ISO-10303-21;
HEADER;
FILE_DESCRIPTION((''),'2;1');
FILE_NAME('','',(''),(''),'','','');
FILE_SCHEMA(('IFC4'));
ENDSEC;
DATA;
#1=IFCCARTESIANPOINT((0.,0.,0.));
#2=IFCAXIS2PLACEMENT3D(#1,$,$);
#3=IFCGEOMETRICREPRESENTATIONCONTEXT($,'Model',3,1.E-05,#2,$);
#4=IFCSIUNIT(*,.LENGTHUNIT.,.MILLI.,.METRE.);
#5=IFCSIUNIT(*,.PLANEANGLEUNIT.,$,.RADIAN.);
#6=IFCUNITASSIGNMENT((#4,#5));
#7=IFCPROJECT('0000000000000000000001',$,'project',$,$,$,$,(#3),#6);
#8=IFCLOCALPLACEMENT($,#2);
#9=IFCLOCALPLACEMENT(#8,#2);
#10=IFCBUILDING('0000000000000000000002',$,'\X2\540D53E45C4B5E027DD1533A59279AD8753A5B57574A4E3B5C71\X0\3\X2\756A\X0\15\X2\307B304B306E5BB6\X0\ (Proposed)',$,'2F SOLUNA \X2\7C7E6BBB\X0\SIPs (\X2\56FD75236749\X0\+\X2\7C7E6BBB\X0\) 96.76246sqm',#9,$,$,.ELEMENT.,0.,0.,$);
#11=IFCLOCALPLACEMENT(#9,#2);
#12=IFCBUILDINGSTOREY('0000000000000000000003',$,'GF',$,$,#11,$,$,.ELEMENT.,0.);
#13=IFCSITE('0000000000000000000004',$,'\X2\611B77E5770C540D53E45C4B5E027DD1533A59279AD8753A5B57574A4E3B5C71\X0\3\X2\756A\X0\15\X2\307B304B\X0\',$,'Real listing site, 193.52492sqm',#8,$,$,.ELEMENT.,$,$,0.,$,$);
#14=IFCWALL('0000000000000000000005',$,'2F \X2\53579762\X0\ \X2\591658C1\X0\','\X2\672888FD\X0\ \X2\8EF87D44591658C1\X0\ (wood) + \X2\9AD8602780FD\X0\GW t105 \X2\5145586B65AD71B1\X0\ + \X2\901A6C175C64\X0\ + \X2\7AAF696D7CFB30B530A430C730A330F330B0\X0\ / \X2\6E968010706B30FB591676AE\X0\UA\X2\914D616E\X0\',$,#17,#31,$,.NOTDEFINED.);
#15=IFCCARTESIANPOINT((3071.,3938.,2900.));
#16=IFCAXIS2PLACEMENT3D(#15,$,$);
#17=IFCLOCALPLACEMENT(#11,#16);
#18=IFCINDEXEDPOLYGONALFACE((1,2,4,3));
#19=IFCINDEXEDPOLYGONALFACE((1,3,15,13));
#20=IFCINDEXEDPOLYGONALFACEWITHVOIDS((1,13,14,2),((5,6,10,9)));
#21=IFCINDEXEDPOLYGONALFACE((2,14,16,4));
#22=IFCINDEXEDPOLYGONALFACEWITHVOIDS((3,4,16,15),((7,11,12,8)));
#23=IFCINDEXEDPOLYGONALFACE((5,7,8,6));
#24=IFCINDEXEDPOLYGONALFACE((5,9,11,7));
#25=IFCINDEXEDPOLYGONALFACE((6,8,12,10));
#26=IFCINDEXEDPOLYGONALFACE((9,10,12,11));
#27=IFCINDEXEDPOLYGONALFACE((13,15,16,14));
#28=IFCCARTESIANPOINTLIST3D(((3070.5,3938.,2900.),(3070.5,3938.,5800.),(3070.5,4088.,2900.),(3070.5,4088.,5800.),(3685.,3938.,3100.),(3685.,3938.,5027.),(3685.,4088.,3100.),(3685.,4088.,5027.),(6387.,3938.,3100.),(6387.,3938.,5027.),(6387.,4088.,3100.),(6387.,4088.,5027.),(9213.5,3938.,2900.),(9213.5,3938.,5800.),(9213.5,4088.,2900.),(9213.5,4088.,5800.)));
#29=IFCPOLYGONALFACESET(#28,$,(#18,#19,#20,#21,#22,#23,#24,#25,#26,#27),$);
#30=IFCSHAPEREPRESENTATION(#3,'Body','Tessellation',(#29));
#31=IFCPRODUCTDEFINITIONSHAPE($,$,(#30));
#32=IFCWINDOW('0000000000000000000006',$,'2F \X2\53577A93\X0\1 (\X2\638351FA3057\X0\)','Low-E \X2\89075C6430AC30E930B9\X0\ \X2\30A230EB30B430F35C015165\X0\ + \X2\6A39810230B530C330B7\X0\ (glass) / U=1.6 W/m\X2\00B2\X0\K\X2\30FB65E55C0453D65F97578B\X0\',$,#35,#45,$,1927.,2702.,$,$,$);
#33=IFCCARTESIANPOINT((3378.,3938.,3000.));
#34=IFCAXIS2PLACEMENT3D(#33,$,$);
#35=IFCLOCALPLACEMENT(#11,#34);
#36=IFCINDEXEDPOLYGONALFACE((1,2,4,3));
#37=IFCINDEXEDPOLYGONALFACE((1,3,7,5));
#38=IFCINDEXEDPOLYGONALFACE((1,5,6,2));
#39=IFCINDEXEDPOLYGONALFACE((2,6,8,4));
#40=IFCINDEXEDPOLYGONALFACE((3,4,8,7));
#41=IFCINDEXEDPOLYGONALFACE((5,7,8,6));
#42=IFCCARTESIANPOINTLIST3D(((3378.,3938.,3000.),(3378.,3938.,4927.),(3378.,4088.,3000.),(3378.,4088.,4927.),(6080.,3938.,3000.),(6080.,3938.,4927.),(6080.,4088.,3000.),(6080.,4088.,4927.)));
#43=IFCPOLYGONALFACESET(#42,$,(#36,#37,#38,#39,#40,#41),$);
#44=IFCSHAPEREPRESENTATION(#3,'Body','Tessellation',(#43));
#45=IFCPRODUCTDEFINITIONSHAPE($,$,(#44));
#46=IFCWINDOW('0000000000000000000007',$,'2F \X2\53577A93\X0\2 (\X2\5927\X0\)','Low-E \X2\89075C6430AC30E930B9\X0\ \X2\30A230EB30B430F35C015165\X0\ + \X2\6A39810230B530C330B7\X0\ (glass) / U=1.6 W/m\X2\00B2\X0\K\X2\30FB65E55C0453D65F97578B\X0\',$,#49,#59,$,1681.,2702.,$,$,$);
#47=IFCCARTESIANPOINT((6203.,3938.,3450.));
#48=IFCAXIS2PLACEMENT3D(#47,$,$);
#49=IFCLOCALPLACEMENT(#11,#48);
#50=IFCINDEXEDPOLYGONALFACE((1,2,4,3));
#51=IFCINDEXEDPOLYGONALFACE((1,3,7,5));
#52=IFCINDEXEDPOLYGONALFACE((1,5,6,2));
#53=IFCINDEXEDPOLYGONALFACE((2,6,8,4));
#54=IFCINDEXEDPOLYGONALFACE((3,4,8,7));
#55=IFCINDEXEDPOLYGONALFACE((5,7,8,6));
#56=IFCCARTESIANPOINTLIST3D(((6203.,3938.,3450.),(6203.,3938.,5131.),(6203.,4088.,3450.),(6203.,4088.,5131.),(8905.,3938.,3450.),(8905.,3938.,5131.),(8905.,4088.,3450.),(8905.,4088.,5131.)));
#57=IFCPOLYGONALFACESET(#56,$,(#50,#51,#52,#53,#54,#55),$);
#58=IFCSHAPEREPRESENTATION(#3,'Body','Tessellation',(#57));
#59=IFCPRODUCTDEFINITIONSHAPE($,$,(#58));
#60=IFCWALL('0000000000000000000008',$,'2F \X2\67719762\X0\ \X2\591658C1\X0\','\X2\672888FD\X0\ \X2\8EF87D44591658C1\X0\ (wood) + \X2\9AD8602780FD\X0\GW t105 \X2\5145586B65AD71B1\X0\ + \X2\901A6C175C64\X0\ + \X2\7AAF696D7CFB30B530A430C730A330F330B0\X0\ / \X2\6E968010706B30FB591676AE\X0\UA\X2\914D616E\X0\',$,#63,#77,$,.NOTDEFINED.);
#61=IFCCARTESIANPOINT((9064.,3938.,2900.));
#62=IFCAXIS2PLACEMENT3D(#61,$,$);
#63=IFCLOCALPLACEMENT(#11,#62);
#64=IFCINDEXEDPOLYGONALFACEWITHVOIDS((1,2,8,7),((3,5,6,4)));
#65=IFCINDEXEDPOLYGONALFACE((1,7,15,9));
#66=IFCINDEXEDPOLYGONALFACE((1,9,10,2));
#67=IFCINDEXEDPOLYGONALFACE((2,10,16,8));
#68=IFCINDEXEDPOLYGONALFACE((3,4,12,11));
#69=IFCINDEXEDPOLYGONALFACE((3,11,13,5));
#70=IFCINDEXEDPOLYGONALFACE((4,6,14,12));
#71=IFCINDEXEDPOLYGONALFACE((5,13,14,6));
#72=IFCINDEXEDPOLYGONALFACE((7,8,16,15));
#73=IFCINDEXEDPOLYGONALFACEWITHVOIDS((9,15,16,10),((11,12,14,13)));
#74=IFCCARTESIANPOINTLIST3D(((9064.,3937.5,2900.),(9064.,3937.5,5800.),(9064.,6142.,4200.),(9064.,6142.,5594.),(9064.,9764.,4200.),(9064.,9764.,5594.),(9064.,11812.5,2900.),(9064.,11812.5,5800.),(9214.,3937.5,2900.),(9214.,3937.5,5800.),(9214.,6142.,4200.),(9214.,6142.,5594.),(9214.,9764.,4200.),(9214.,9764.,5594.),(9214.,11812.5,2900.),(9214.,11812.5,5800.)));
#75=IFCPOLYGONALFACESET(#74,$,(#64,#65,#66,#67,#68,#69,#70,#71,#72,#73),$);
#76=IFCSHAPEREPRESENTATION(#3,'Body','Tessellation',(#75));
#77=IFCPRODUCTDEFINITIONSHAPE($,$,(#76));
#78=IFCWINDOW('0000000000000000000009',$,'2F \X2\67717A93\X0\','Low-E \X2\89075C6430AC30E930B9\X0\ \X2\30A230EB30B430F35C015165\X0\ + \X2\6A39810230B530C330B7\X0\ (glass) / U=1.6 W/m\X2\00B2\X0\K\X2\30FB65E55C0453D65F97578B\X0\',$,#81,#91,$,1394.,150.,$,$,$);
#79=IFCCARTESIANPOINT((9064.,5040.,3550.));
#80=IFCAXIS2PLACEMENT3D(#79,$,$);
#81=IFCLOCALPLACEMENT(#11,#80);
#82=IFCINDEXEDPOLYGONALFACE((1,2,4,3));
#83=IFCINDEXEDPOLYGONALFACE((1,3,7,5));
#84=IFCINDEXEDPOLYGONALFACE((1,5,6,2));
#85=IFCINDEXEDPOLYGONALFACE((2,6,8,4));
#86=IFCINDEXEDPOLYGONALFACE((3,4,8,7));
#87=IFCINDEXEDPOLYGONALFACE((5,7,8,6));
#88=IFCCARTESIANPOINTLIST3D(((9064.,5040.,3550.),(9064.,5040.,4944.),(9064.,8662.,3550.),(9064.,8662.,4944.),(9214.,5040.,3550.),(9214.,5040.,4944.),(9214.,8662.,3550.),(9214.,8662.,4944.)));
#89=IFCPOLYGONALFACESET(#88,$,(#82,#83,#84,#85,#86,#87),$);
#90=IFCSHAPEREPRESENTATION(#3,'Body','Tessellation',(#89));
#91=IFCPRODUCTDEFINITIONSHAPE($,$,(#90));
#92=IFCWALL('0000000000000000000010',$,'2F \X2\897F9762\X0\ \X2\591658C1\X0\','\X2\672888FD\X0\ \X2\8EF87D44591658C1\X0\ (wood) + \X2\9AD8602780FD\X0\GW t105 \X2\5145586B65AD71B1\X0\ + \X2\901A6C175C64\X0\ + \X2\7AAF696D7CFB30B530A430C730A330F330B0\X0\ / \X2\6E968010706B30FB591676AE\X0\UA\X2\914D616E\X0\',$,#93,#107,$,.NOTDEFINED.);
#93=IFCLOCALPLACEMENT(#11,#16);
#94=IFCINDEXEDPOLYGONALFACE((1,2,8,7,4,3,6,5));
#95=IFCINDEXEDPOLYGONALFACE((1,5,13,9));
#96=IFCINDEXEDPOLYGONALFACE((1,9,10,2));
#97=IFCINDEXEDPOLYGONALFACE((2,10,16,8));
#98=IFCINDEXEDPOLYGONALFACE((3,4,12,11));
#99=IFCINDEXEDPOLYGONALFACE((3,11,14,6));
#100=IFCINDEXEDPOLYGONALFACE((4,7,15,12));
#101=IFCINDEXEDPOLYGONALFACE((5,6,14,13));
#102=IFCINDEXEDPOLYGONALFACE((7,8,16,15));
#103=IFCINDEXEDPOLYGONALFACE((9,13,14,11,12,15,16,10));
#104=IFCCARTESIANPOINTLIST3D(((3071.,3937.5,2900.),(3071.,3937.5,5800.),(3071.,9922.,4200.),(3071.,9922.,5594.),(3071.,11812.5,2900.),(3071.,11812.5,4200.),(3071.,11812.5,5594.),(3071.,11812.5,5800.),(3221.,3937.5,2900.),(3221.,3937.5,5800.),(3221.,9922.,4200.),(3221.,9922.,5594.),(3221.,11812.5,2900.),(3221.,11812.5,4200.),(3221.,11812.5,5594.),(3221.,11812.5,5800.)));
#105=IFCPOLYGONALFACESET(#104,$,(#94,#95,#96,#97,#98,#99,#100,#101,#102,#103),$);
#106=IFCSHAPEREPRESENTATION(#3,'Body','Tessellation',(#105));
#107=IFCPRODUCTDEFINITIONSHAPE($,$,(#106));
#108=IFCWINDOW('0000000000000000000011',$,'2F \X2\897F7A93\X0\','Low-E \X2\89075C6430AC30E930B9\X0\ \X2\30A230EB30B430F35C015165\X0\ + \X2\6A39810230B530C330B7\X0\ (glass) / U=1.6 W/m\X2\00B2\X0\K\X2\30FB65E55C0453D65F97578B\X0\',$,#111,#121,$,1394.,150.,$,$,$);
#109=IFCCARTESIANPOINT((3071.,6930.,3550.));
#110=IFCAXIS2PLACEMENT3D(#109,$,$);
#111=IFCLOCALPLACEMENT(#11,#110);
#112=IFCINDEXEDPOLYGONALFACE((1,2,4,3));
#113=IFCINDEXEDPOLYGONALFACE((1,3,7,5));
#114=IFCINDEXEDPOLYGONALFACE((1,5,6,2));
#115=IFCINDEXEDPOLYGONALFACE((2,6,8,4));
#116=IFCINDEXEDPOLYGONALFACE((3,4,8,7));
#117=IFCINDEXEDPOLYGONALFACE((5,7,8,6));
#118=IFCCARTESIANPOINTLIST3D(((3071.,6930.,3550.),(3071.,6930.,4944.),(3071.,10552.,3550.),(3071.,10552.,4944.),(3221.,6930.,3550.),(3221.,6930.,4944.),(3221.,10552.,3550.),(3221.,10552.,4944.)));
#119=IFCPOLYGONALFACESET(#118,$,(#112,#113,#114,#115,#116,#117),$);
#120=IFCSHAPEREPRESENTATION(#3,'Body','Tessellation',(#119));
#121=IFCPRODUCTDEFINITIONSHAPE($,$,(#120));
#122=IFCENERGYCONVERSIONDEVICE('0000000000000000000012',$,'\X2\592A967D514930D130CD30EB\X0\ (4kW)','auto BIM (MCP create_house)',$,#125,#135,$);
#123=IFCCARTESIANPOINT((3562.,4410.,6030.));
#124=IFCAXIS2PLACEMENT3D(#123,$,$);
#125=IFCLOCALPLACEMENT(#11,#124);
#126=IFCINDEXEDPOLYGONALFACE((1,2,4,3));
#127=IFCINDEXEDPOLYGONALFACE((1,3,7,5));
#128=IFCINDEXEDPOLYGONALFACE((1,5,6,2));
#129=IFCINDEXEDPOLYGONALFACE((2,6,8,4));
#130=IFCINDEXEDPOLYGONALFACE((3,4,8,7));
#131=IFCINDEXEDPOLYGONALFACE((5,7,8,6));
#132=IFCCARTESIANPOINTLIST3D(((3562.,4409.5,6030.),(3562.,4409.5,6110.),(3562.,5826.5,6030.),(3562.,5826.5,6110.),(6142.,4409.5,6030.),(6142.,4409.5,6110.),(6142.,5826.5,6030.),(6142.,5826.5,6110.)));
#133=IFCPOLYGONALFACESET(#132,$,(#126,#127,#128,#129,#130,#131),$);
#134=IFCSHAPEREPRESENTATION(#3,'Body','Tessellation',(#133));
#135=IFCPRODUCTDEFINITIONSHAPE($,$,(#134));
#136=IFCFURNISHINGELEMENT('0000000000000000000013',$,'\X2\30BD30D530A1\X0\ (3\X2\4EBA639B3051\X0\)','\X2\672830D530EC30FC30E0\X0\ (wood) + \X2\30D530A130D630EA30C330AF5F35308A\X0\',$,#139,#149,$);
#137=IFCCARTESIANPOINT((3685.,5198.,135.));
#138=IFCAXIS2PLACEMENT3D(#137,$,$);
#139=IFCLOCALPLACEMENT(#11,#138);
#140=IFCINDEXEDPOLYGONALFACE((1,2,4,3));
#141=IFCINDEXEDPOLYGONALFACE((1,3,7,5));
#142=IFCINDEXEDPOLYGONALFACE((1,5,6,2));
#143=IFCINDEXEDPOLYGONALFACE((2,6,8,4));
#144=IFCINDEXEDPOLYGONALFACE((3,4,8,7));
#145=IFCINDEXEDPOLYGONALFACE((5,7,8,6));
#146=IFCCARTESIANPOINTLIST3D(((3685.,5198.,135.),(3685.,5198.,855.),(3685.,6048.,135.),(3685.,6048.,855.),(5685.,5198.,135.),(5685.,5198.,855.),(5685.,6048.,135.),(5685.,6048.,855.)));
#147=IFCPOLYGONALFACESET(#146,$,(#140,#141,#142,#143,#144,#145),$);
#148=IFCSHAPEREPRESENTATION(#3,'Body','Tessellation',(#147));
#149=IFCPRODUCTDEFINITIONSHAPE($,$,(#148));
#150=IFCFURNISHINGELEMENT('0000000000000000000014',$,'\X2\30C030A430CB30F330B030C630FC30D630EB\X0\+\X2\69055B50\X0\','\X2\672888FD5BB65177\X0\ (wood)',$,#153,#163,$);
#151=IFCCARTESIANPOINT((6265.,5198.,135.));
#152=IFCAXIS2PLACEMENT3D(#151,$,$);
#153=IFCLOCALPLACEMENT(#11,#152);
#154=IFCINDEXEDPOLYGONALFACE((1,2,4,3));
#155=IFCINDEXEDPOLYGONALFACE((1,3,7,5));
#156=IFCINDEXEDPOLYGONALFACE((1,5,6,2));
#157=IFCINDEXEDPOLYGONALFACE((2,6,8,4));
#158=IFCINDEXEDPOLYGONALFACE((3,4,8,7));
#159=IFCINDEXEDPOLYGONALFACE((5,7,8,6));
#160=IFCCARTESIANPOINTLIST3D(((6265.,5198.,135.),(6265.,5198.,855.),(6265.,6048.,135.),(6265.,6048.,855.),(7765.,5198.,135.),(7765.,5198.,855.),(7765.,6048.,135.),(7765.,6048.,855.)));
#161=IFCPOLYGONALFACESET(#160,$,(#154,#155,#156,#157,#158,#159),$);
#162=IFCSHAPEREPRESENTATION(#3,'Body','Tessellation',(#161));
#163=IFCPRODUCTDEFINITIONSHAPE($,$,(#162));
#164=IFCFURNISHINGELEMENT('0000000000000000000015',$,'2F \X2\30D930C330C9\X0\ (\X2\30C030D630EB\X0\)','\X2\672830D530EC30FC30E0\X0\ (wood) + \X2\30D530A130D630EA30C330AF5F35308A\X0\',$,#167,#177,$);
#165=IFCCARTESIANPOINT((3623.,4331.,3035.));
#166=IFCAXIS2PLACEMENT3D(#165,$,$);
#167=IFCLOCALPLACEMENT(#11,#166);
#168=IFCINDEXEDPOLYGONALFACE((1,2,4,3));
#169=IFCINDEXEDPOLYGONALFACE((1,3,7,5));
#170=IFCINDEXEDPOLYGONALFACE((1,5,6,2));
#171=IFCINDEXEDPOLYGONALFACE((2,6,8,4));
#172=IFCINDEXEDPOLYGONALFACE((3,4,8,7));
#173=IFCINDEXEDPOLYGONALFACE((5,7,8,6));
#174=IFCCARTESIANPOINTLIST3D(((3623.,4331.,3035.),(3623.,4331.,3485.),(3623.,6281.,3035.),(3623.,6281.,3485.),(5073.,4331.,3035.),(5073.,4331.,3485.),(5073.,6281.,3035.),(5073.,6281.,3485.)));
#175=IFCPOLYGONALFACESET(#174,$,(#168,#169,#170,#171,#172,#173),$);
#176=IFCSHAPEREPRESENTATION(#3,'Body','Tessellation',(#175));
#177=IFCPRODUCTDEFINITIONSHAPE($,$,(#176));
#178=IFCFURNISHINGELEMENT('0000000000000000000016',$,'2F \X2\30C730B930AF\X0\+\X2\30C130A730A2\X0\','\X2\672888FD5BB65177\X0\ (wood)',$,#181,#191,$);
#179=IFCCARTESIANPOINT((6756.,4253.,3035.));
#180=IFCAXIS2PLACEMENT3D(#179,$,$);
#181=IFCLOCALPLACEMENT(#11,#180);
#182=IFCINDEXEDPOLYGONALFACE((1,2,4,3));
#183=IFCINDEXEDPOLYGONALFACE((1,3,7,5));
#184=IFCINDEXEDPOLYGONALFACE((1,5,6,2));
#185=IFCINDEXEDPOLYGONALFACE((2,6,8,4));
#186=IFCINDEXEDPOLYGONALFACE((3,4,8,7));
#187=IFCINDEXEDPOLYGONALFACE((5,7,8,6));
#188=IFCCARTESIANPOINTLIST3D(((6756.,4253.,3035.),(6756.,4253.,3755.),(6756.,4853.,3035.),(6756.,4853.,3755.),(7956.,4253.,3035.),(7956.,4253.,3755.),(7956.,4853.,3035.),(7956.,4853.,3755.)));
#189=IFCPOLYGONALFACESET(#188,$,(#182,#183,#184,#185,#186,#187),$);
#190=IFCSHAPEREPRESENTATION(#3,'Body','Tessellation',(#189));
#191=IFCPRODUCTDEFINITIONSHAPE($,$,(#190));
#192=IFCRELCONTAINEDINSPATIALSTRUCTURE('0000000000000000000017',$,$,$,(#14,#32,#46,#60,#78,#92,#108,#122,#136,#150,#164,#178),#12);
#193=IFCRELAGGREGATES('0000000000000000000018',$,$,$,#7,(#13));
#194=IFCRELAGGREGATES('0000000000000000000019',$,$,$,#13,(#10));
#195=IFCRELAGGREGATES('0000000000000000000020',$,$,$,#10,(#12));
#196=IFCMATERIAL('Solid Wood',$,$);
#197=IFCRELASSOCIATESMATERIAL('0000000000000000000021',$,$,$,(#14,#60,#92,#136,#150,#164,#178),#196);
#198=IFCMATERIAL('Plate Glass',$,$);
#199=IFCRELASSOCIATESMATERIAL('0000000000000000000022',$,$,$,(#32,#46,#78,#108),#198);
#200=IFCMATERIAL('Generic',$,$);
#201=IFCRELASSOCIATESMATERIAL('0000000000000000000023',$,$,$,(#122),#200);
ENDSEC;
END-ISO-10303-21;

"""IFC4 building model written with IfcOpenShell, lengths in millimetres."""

from ifc_helpers import new_model, si_unit, frame, frame_2d, origin, place, context, project, spatial, rectangle, extrude, material, element, fill, save


model = new_model("IFC4")

# Units and contexts
model_context = context("Model", 3, precision=1e-05, world=origin())
ifc_project = project(units=[si_unit("LENGTHUNIT", "METRE", prefix="MILLI"), si_unit("PLANEANGLEUNIT", "RADIAN")], contexts=[model_context])

# Site, building, storey
site_placement = place(None, origin())
site = spatial("IfcSite", under=ifc_project, at=site_placement, Name="愛知県名古屋市緑区大高町字坊主山3番15ほか", ObjectType="Real listing site, 193.52492sqm", CompositionType="ELEMENT", RefElevation=0.0)
building_placement = place(site_placement, origin())
building = spatial("IfcBuilding", under=site, at=building_placement, Name="名古屋市緑区大高町字坊主山3番15ほかの家 (Proposed)", ObjectType="2F SOLUNA 籾殻SIPs (国産杉+籾殻) 96.76246sqm", CompositionType="ELEMENT", ElevationOfRefHeight=0.0, ElevationOfTerrain=0.0)
storey_placement = place(building_placement, origin())
storey = spatial("IfcBuildingStorey", under=building, at=storey_placement, Name="GF", CompositionType="ELEMENT", Elevation=0.0)

# Shared definitions
ifc_material_1 = material(Name="Solid Wood")

# Wall, openings, windows
wall_1_placement = place(storey_placement, frame((3071.0, 3938.0, 2900.0)))
wall_1 = element("IfcWall", 1, at=wall_1_placement, inside=storey, material=ifc_material_1, Name="2F 南面 外壁", Description="木製 軸組外壁 (wood) + 高性能GW t105 充填断熱 + 通気層 + 窯業系サイディング / 準耐火・外皮UA配慮", PredefinedType="NOTDEFINED", context=model_context, shape_type="SweptSolid", body=[
    extrude(rectangle(XDim=6143.0, YDim=150.0, at=frame_2d((3071.0, 75.0))), frame((3071.0, 3938.0, 2900.0)), (0.0, 0.0, 1.0), 2900.0),
])
opening_1_placement = place(storey_placement, frame((3378.0, 3938.0, 3000.0)))
opening_1 = element("IfcOpeningElement", 2, at=opening_1_placement, cuts=wall_1, PredefinedType="NOTDEFINED", context=model_context, shape_type="SweptSolid", body=[
    extrude(rectangle(XDim=2702.0, YDim=150.0, at=frame_2d((1351.0, 75.0))), frame((3378.0, 3938.0, 3000.0)), (0.0, 0.0, 1.0), 1927.0),
])
opening_2_placement = place(storey_placement, frame((6203.0, 3938.0, 3450.0)))
opening_2 = element("IfcOpeningElement", 3, at=opening_2_placement, cuts=wall_1, PredefinedType="NOTDEFINED", context=model_context, shape_type="SweptSolid", body=[
    extrude(rectangle(XDim=2702.0, YDim=150.0, at=frame_2d((1351.0, 75.0))), frame((6203.0, 3938.0, 3450.0)), (0.0, 0.0, 1.0), 1681.0),
])
ifc_material_2 = material(Name="Plate Glass")
window_1_placement = place(storey_placement, frame((3378.0, 3938.0, 3000.0)))
window_1 = element("IfcWindow", 4, at=window_1_placement, inside=storey, material=ifc_material_2, Name="2F 南窓1 (掃出し)", Description="Low-E 複層ガラス アルゴン封入 + 樹脂サッシ (glass) / U=1.6 W/m²K・日射取得型", OverallHeight=1927.0, OverallWidth=2702.0, context=model_context, shape_type="SweptSolid", body=[
    extrude(rectangle(XDim=2702.0, YDim=150.0, at=frame_2d((1351.0, 75.0))), frame((3378.0, 3938.0, 3000.0)), (0.0, 0.0, 1.0), 1927.0),
])
fill(opening_1, window_1)
window_2_placement = place(storey_placement, frame((6203.0, 3938.0, 3450.0)))
window_2 = element("IfcWindow", 5, at=window_2_placement, inside=storey, material=ifc_material_2, Name="2F 南窓2 (大)", Description="Low-E 複層ガラス アルゴン封入 + 樹脂サッシ (glass) / U=1.6 W/m²K・日射取得型", OverallHeight=1681.0, OverallWidth=2702.0, context=model_context, shape_type="SweptSolid", body=[
    extrude(rectangle(XDim=2702.0, YDim=150.0, at=frame_2d((1351.0, 75.0))), frame((6203.0, 3938.0, 3450.0)), (0.0, 0.0, 1.0), 1681.0),
])
fill(opening_2, window_2)

# Walls, openings, windows
wall_2_placement = place(storey_placement, frame((9064.0, 3938.0, 2900.0)))
wall_2 = element("IfcWall", 6, at=wall_2_placement, inside=storey, material=ifc_material_1, Name="2F 東面 外壁", Description="木製 軸組外壁 (wood) + 高性能GW t105 充填断熱 + 通気層 + 窯業系サイディング / 準耐火・外皮UA配慮", PredefinedType="NOTDEFINED", context=model_context, shape_type="SweptSolid", body=[
    extrude(rectangle(XDim=150.0, YDim=7875.0, at=frame_2d((75.0, 3937.0))), frame((9064.0, 3938.0, 2900.0)), (0.0, 0.0, 1.0), 2900.0),
])
opening_3_placement = place(storey_placement, frame((9064.0, 5040.0, 3550.0)))
opening_3 = element("IfcOpeningElement", 7, at=opening_3_placement, cuts=wall_2, PredefinedType="NOTDEFINED", context=model_context, shape_type="SweptSolid", body=[
    extrude(rectangle(XDim=150.0, YDim=3622.0, at=frame_2d((75.0, 1811.0))), frame((9064.0, 5040.0, 3550.0)), (0.0, 0.0, 1.0), 1394.0),
])
window_3_placement = place(storey_placement, frame((9064.0, 5040.0, 3550.0)))
window_3 = element("IfcWindow", 8, at=window_3_placement, inside=storey, material=ifc_material_2, Name="2F 東窓", Description="Low-E 複層ガラス アルゴン封入 + 樹脂サッシ (glass) / U=1.6 W/m²K・日射取得型", OverallHeight=1394.0, OverallWidth=150.0, context=model_context, shape_type="SweptSolid", body=[
    extrude(rectangle(XDim=150.0, YDim=3622.0, at=frame_2d((75.0, 1811.0))), frame((9064.0, 5040.0, 3550.0)), (0.0, 0.0, 1.0), 1394.0),
])
fill(opening_3, window_3)
wall_3_placement = place(storey_placement, frame((3071.0, 3938.0, 2900.0)))
wall_3 = element("IfcWall", 9, at=wall_3_placement, inside=storey, material=ifc_material_1, Name="2F 西面 外壁", Description="木製 軸組外壁 (wood) + 高性能GW t105 充填断熱 + 通気層 + 窯業系サイディング / 準耐火・外皮UA配慮", PredefinedType="NOTDEFINED", context=model_context, shape_type="SweptSolid", body=[
    extrude(rectangle(XDim=150.0, YDim=7875.0, at=frame_2d((75.0, 3937.0))), frame((3071.0, 3938.0, 2900.0)), (0.0, 0.0, 1.0), 2900.0),
])
opening_4_placement = place(storey_placement, frame((3071.0, 6930.0, 3550.0)))
opening_4 = element("IfcOpeningElement", 10, at=opening_4_placement, cuts=wall_3, PredefinedType="NOTDEFINED", context=model_context, shape_type="SweptSolid", body=[
    extrude(rectangle(XDim=150.0, YDim=3622.0, at=frame_2d((75.0, 1811.0))), frame((3071.0, 6930.0, 3550.0)), (0.0, 0.0, 1.0), 1394.0),
])
window_4_placement = place(storey_placement, frame((3071.0, 6930.0, 3550.0)))
window_4 = element("IfcWindow", 11, at=window_4_placement, inside=storey, material=ifc_material_2, Name="2F 西窓", Description="Low-E 複層ガラス アルゴン封入 + 樹脂サッシ (glass) / U=1.6 W/m²K・日射取得型", OverallHeight=1394.0, OverallWidth=150.0, context=model_context, shape_type="SweptSolid", body=[
    extrude(rectangle(XDim=150.0, YDim=3622.0, at=frame_2d((75.0, 1811.0))), frame((3071.0, 6930.0, 3550.0)), (0.0, 0.0, 1.0), 1394.0),
])
fill(opening_4, window_4)

# Shared definitions
ifc_material_3 = material(Name="Generic")

# Energy conversion device
energy_conversion_device_placement = place(storey_placement, frame((3562.0, 4410.0, 6030.0)))
element("IfcEnergyConversionDevice", 12, at=energy_conversion_device_placement, inside=storey, material=ifc_material_3, Name="太陽光パネル (4kW)", Description="auto BIM (MCP create_house)", context=model_context, shape_type="SweptSolid", body=[
    extrude(rectangle(XDim=2580.0, YDim=1417.0, at=frame_2d((1290.0, 708.0))), frame((3562.0, 4410.0, 6030.0)), (0.0, 0.0, 1.0), 80.0),
])

# Furnishing elements
furnishing_1_placement = place(storey_placement, frame((3685.0, 5198.0, 135.0)))
element("IfcFurnishingElement", 13, at=furnishing_1_placement, inside=storey, material=ifc_material_1, Name="ソファ (3人掛け)", Description="木フレーム (wood) + ファブリック張り", context=model_context, shape_type="SweptSolid", body=[
    extrude(rectangle(XDim=2000.0, YDim=850.0, at=frame_2d((1000.0, 425.0))), frame((3685.0, 5198.0, 135.0)), (0.0, 0.0, 1.0), 720.0),
])
furnishing_2_placement = place(storey_placement, frame((6265.0, 5198.0, 135.0)))
element("IfcFurnishingElement", 14, at=furnishing_2_placement, inside=storey, material=ifc_material_1, Name="ダイニングテーブル+椅子", Description="木製家具 (wood)", context=model_context, shape_type="SweptSolid", body=[
    extrude(rectangle(XDim=1500.0, YDim=850.0, at=frame_2d((750.0, 425.0))), frame((6265.0, 5198.0, 135.0)), (0.0, 0.0, 1.0), 720.0),
])
furnishing_3_placement = place(storey_placement, frame((3623.0, 4331.0, 3035.0)))
element("IfcFurnishingElement", 15, at=furnishing_3_placement, inside=storey, material=ifc_material_1, Name="2F ベッド (ダブル)", Description="木フレーム (wood) + ファブリック張り", context=model_context, shape_type="SweptSolid", body=[
    extrude(rectangle(XDim=1450.0, YDim=1950.0, at=frame_2d((725.0, 975.0))), frame((3623.0, 4331.0, 3035.0)), (0.0, 0.0, 1.0), 450.0),
])
furnishing_4_placement = place(storey_placement, frame((6756.0, 4253.0, 3035.0)))
element("IfcFurnishingElement", 16, at=furnishing_4_placement, inside=storey, material=ifc_material_1, Name="2F デスク+チェア", Description="木製家具 (wood)", context=model_context, shape_type="SweptSolid", body=[
    extrude(rectangle(XDim=1200.0, YDim=600.0, at=frame_2d((600.0, 300.0))), frame((6756.0, 4253.0, 3035.0)), (0.0, 0.0, 1.0), 720.0),
])

save(model, "model.ifc")
